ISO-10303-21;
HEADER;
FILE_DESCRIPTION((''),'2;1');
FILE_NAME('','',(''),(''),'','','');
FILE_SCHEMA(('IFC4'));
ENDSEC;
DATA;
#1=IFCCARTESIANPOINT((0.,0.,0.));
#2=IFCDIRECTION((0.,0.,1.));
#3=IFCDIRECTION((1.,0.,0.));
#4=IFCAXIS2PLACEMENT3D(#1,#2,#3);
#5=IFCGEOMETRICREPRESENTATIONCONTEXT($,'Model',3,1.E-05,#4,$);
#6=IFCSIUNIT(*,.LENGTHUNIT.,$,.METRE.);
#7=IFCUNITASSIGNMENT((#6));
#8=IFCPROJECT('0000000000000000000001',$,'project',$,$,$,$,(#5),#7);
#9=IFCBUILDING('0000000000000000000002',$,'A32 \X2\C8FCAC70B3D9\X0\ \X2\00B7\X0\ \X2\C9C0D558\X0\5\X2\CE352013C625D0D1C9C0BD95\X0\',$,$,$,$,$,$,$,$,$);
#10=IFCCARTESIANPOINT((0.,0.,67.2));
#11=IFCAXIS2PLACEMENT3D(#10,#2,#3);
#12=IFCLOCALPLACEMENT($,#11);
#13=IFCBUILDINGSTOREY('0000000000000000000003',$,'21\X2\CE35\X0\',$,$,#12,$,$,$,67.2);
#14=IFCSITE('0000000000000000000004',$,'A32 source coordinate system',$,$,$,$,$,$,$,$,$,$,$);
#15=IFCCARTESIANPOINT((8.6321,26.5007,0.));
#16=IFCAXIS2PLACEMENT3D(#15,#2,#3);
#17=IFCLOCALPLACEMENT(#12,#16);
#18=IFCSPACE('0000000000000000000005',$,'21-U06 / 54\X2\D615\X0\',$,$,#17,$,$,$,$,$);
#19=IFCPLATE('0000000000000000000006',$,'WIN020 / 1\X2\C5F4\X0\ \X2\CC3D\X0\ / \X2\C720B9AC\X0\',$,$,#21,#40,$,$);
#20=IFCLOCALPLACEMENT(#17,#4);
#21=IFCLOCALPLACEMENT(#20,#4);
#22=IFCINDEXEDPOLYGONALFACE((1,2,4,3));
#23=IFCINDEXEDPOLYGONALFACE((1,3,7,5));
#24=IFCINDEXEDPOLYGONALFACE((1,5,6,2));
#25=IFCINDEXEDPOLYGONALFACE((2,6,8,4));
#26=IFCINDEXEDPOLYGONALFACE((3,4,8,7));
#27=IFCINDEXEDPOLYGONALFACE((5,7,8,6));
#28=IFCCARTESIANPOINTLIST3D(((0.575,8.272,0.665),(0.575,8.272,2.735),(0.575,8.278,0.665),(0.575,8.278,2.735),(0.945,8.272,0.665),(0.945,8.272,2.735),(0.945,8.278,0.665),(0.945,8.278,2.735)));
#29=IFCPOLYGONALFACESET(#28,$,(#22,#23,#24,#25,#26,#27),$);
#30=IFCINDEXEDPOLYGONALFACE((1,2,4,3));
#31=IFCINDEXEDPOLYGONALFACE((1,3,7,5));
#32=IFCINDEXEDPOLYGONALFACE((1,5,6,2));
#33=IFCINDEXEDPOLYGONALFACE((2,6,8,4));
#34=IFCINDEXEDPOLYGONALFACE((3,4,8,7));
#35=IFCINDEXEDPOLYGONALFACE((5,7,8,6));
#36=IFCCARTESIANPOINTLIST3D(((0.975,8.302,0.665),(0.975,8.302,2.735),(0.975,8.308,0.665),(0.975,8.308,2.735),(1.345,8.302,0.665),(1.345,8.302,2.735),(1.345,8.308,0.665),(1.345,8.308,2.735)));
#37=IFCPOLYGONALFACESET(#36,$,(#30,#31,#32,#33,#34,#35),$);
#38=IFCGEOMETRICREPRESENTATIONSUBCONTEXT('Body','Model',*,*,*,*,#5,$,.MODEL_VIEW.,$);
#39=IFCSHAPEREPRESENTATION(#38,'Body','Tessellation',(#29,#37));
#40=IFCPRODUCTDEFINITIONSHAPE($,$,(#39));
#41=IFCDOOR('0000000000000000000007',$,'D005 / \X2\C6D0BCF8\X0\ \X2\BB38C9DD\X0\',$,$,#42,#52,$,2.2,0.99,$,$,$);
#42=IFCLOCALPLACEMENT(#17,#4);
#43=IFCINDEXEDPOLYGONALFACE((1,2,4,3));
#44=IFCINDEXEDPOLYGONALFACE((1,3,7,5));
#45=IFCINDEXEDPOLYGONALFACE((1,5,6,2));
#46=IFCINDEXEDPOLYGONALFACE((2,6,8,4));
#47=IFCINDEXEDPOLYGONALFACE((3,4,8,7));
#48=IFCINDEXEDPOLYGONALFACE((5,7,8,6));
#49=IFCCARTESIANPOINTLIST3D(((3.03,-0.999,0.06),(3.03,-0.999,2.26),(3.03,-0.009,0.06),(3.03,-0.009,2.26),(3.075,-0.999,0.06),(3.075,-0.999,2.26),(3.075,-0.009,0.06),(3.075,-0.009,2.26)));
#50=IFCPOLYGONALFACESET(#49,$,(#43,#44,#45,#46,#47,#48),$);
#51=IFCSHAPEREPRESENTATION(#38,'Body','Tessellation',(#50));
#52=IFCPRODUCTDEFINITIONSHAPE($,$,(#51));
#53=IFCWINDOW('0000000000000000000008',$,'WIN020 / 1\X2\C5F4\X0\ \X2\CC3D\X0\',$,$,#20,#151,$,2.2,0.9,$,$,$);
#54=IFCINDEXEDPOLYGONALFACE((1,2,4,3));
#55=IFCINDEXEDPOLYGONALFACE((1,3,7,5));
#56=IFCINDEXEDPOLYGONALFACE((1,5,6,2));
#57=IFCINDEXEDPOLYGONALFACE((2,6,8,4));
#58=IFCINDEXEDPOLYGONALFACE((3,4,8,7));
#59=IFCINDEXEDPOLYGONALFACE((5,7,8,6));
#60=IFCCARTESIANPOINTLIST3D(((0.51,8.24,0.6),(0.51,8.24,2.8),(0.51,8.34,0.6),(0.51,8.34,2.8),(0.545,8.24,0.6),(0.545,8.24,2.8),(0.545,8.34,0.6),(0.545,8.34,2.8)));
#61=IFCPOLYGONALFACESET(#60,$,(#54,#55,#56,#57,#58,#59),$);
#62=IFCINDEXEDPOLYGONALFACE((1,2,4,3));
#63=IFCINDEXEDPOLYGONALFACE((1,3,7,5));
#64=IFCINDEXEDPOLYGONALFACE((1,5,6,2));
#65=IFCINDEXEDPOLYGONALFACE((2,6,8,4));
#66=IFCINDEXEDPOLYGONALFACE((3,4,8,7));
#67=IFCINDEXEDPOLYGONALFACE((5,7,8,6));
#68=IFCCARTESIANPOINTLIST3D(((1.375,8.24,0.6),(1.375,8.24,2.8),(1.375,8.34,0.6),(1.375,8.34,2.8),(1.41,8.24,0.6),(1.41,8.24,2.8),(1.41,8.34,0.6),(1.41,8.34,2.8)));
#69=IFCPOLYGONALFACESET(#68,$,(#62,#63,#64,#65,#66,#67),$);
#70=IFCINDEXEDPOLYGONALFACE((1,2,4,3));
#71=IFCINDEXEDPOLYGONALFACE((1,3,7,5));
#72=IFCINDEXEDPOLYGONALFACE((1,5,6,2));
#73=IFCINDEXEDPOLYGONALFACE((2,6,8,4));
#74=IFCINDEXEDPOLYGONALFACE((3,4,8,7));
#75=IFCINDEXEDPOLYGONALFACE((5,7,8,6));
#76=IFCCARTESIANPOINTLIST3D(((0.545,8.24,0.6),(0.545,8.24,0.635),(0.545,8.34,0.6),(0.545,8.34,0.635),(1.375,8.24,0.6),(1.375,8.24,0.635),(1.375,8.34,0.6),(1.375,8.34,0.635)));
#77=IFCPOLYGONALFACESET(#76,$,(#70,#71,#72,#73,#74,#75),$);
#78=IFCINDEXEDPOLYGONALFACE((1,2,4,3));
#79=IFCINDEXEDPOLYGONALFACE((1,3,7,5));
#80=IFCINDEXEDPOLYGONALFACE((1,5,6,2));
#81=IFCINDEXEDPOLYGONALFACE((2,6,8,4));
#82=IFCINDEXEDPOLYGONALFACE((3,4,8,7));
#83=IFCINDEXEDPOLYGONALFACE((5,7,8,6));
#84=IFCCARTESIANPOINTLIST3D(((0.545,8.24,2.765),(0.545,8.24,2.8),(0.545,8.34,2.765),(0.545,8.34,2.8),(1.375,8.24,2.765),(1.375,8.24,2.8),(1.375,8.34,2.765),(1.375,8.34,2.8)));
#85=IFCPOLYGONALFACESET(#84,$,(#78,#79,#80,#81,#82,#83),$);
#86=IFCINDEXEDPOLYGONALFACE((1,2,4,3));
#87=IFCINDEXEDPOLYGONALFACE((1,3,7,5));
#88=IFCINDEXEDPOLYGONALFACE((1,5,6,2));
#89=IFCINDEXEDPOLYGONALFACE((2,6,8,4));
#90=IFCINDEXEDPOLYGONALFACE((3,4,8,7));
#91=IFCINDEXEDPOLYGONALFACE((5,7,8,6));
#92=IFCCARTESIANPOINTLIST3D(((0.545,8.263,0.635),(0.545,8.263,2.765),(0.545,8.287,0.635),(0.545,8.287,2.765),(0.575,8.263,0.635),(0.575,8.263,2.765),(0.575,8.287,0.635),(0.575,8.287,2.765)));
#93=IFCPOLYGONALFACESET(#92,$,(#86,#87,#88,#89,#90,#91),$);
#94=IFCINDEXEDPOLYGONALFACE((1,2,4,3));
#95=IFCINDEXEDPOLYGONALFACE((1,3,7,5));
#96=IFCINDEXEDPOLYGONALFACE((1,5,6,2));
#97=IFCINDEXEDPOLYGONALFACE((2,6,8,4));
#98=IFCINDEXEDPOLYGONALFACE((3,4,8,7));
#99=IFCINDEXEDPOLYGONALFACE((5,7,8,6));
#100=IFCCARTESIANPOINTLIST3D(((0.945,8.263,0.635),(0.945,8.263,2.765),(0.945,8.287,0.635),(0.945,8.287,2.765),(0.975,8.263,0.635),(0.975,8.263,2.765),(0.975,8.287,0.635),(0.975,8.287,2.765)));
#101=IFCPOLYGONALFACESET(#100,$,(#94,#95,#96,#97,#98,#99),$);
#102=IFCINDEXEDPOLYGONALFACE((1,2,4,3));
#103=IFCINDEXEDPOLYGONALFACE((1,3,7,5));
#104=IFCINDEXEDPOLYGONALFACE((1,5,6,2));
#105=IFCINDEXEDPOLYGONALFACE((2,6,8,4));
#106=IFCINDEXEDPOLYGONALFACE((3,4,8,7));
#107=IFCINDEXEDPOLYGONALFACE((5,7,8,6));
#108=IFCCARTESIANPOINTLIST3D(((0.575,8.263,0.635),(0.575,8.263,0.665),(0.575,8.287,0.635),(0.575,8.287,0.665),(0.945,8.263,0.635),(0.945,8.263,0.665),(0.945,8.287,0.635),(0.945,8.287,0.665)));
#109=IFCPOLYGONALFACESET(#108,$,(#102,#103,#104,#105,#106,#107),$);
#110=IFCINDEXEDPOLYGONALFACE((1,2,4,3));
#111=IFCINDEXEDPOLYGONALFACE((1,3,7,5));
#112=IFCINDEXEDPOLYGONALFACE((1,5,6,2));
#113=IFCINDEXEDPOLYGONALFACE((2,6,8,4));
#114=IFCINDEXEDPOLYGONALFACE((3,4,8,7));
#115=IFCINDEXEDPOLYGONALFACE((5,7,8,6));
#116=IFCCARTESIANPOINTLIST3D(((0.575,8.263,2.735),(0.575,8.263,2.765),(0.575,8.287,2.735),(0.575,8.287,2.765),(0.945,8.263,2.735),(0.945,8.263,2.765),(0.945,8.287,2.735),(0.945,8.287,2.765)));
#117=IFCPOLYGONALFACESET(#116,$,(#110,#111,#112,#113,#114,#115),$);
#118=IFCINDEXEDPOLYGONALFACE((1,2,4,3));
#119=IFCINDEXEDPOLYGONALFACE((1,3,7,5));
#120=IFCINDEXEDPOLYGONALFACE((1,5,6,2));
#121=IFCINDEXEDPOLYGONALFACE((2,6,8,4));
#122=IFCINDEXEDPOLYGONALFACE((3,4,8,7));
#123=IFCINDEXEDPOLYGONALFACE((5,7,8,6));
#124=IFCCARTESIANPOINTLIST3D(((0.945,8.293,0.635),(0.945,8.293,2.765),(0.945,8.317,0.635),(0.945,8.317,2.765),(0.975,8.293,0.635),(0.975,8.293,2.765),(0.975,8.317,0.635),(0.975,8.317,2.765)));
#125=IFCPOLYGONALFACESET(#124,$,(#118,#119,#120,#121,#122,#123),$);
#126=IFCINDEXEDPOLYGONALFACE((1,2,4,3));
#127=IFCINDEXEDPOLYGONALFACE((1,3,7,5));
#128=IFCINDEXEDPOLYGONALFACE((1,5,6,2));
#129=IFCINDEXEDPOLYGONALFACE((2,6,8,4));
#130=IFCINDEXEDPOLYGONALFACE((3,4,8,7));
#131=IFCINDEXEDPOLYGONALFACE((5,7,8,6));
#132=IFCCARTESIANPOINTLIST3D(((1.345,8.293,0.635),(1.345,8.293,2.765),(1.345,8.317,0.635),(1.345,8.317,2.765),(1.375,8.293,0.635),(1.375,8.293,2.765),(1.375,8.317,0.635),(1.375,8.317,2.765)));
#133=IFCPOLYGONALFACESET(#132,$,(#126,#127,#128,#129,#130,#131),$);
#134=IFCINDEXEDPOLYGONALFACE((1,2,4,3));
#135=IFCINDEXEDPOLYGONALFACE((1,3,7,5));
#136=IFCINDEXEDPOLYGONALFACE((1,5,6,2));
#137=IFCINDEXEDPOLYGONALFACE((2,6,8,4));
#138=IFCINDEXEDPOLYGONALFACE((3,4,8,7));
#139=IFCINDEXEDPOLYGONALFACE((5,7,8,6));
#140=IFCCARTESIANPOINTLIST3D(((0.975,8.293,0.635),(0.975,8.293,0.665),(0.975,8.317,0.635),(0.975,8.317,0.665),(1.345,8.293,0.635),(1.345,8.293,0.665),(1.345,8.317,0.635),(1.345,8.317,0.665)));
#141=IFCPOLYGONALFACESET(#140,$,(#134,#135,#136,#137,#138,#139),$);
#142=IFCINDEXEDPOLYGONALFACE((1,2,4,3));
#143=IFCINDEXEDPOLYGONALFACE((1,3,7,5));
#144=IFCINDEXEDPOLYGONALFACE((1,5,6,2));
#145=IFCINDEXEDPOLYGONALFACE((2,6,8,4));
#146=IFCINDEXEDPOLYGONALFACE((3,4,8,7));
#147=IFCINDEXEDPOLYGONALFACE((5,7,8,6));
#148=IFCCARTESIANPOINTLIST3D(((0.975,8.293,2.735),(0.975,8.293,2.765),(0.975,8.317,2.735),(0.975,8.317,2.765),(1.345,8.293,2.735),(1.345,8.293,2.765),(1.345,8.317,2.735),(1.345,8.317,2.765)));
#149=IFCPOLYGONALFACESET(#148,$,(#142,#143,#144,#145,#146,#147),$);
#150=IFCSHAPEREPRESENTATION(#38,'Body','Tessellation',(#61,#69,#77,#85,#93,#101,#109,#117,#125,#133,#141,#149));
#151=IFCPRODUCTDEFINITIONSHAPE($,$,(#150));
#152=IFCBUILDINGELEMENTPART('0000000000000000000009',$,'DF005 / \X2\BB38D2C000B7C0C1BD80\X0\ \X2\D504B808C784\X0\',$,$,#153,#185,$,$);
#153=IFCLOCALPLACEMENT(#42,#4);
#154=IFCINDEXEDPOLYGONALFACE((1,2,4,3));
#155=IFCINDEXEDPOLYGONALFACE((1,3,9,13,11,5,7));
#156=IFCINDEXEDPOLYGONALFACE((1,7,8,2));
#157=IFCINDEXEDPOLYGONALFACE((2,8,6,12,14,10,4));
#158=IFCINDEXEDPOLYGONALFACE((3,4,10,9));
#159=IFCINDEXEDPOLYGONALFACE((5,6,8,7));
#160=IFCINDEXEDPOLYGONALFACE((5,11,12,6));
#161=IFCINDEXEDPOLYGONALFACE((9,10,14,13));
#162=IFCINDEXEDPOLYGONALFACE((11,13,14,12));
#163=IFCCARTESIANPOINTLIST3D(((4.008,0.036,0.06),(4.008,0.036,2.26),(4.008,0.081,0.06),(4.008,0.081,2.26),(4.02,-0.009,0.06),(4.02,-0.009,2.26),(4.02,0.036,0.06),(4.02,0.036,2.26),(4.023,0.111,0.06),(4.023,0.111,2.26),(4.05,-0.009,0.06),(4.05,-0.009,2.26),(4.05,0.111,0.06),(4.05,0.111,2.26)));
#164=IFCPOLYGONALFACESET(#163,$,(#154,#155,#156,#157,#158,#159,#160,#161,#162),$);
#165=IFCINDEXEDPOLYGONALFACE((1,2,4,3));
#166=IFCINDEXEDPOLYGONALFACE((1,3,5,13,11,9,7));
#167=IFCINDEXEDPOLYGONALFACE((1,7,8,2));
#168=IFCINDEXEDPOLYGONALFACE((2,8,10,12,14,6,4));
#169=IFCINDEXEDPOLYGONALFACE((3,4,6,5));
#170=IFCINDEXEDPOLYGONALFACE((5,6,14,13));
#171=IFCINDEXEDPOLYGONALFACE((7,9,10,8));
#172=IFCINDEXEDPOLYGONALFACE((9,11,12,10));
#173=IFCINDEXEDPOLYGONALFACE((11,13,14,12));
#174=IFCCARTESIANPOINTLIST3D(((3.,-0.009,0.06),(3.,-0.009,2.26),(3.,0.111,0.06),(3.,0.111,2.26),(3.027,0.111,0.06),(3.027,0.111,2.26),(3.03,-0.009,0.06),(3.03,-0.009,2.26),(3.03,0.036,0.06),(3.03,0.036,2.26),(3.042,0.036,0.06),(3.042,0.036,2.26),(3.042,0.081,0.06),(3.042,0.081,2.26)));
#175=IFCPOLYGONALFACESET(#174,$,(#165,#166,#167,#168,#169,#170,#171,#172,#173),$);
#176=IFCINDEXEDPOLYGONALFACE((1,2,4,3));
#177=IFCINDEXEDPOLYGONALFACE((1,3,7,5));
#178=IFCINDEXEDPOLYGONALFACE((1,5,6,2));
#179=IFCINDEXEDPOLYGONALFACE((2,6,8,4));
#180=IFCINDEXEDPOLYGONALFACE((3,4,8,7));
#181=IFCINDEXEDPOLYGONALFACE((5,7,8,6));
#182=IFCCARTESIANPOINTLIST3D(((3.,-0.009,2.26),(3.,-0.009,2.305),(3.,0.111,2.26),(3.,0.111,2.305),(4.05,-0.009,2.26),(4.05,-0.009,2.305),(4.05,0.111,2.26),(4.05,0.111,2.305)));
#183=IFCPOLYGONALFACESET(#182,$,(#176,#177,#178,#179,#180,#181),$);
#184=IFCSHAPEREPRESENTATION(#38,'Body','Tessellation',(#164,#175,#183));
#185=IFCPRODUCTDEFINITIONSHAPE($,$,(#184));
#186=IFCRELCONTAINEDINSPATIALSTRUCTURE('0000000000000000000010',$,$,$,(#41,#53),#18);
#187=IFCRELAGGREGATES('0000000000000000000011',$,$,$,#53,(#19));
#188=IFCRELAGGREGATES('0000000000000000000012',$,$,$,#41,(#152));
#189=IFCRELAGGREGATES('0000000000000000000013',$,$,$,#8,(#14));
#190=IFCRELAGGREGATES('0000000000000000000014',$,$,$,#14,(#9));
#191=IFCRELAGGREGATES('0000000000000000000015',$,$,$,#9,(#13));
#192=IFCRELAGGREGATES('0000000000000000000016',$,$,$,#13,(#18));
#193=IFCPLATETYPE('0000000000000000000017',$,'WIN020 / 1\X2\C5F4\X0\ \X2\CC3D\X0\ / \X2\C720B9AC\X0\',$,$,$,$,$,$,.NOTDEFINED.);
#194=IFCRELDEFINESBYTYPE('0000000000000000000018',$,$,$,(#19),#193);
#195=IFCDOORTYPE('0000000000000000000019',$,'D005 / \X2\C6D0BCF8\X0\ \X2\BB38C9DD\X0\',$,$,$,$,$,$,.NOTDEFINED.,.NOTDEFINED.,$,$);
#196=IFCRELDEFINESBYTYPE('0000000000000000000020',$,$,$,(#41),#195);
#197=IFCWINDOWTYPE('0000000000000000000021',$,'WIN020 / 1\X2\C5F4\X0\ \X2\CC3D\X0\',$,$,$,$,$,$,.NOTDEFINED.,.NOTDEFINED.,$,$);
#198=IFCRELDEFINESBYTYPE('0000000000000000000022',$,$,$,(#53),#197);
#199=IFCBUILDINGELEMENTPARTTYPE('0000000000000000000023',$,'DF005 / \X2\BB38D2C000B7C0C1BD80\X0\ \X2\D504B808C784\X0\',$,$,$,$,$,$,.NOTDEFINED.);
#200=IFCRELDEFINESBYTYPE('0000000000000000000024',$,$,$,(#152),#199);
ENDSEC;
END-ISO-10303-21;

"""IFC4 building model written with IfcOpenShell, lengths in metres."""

from ifc_helpers import new_model, si_unit, frame, origin, origin_with_axes, place, context, subcontext, project, spatial, polyline, outline, extrude, source, transform, mapped, type_object, type_shapes, element, aggregate, save


model = new_model("IFC4")

# Units and contexts
model_context = context("Model", 3, precision=1e-05, world=origin_with_axes())
body_context = subcontext(model_context, "Body", "Model", "MODEL_VIEW")
ifc_project = project(units=[si_unit("LENGTHUNIT", "METRE")], contexts=[model_context])

# Plate
storey_placement = place(None, frame((0.0, 0.0, 67.2), z_axis=(0.0, 0.0, 1.0), x_axis=(1.0, 0.0, 0.0)))
space_1_placement = place(storey_placement, frame((8.6321, 26.5007, 0.0), z_axis=(0.0, 0.0, 1.0), x_axis=(1.0, 0.0, 0.0)))
plate_type_1 = type_object("IfcPlateType", Name="WIN020 / 1열 창 / 유리", PredefinedType="NOTDEFINED")
shared_shape_1 = source(origin(), body_context, "Body", "SweptSolid", [
    extrude(outline(polyline([(0.575, 8.272), (0.575, 8.278), (0.945, 8.278), (0.945, 8.272), (0.575, 8.272)])), frame((0.0, 0.0, 0.665)), (0.0, 0.0, 1.0), 2.07),
    extrude(outline(polyline([(0.975, 8.302), (0.975, 8.308), (1.345, 8.308), (1.345, 8.302), (0.975, 8.302)])), frame((0.0, 0.0, 0.665)), (0.0, 0.0, 1.0), 2.07),
])
type_shapes(plate_type_1, [shared_shape_1])
window_1_placement = place(space_1_placement, origin_with_axes())
plate_1_placement = place(window_1_placement, origin_with_axes())
plate_1 = element("IfcPlate", 1, at=plate_1_placement, type_object=plate_type_1, Name="WIN020 / 1열 창 / 유리", context=body_context, shape_type="MappedRepresentation", body=[
    mapped(shared_shape_1, transform((0.0, 0.0, 0.0), scale=1.0)),
])

# Site, building, storey, space
site = spatial("IfcSite", under=ifc_project, Name="A32 source coordinate system")
building = spatial("IfcBuilding", under=site, Name="A32 주거동 · 지하5층–옥탑지붕")
storey = spatial("IfcBuildingStorey", under=building, at=storey_placement, Name="21층", Elevation=67.2)
space_1 = spatial("IfcSpace", under=storey, at=space_1_placement, Name="21-U06 / 54형")

# Door
door_type_1 = type_object("IfcDoorType", Name="D005 / 원본 문짝", OperationType="NOTDEFINED", PredefinedType="NOTDEFINED")
shared_shape_2 = source(origin(), body_context, "Body", "SweptSolid", [
    extrude(outline(polyline([(3.075, -0.999), (3.03, -0.999), (3.03, -0.009), (3.075, -0.009), (3.075, -0.999)])), frame((0.0, 0.0, 0.06)), (0.0, 0.0, 1.0), 2.2),
])
type_shapes(door_type_1, [shared_shape_2])
door_1_placement = place(space_1_placement, origin_with_axes())
door_1 = element("IfcDoor", 2, at=door_1_placement, inside=space_1, type_object=door_type_1, Name="D005 / 원본 문짝", OverallHeight=2.2, OverallWidth=0.99, context=body_context, shape_type="MappedRepresentation", body=[
    mapped(shared_shape_2, transform((0.0, 0.0, 0.0), scale=1.0)),
])

# Window
window_type_1 = type_object("IfcWindowType", Name="WIN020 / 1열 창", PartitioningType="NOTDEFINED", PredefinedType="NOTDEFINED")
shared_shape_3 = source(origin(), body_context, "Body", "SweptSolid", [
    extrude(outline(polyline([(0.51, 8.24), (0.51, 8.34), (0.545, 8.34), (0.545, 8.24), (0.51, 8.24)])), frame((0.0, 0.0, 0.6)), (0.0, 0.0, 1.0), 2.2),
    extrude(outline(polyline([(1.375, 8.24), (1.375, 8.34), (1.41, 8.34), (1.41, 8.24), (1.375, 8.24)])), frame((0.0, 0.0, 0.6)), (0.0, 0.0, 1.0), 2.2),
    extrude(outline(polyline([(0.545, 8.24), (0.545, 8.34), (1.375, 8.34), (1.375, 8.24), (0.545, 8.24)])), frame((0.0, 0.0, 0.6)), (0.0, 0.0, 1.0), 0.035),
    extrude(outline(polyline([(0.545, 8.24), (0.545, 8.34), (1.375, 8.34), (1.375, 8.24), (0.545, 8.24)])), frame((0.0, 0.0, 2.765)), (0.0, 0.0, 1.0), 0.035),
    extrude(outline(polyline([(0.545, 8.263), (0.545, 8.287), (0.575, 8.287), (0.575, 8.263), (0.545, 8.263)])), frame((0.0, 0.0, 0.635)), (0.0, 0.0, 1.0), 2.13),
    extrude(outline(polyline([(0.945, 8.263), (0.945, 8.287), (0.975, 8.287), (0.975, 8.263), (0.945, 8.263)])), frame((0.0, 0.0, 0.635)), (0.0, 0.0, 1.0), 2.13),
    extrude(outline(polyline([(0.575, 8.263), (0.575, 8.287), (0.945, 8.287), (0.945, 8.263), (0.575, 8.263)])), frame((0.0, 0.0, 0.635)), (0.0, 0.0, 1.0), 0.03),
    extrude(outline(polyline([(0.575, 8.263), (0.575, 8.287), (0.945, 8.287), (0.945, 8.263), (0.575, 8.263)])), frame((0.0, 0.0, 2.735)), (0.0, 0.0, 1.0), 0.03),
    extrude(outline(polyline([(0.945, 8.293), (0.945, 8.317), (0.975, 8.317), (0.975, 8.293), (0.945, 8.293)])), frame((0.0, 0.0, 0.635)), (0.0, 0.0, 1.0), 2.13),
    extrude(outline(polyline([(1.345, 8.293), (1.345, 8.317), (1.375, 8.317), (1.375, 8.293), (1.345, 8.293)])), frame((0.0, 0.0, 0.635)), (0.0, 0.0, 1.0), 2.13),
    extrude(outline(polyline([(0.975, 8.293), (0.975, 8.317), (1.345, 8.317), (1.345, 8.293), (0.975, 8.293)])), frame((0.0, 0.0, 0.635)), (0.0, 0.0, 1.0), 0.03),
    extrude(outline(polyline([(0.975, 8.293), (0.975, 8.317), (1.345, 8.317), (1.345, 8.293), (0.975, 8.293)])), frame((0.0, 0.0, 2.735)), (0.0, 0.0, 1.0), 0.03),
])
type_shapes(window_type_1, [shared_shape_3])
window_1 = element("IfcWindow", 3, at=window_1_placement, inside=space_1, type_object=window_type_1, Name="WIN020 / 1열 창", OverallHeight=2.2, OverallWidth=0.9, context=body_context, shape_type="MappedRepresentation", body=[
    mapped(shared_shape_3, transform((0.0, 0.0, 0.0), scale=1.0)),
])
aggregate(window_1, [plate_1])

# Building element part
building_element_part_type_1 = type_object("IfcBuildingElementPartType", Name="DF005 / 문틀·상부 프레임", PredefinedType="NOTDEFINED")
shared_shape_4 = source(origin(), body_context, "Body", "SweptSolid", [
    extrude(outline(polyline([(4.02, -0.009), (4.02, 0.036), (4.008, 0.036), (4.008, 0.081), (4.023, 0.111), (4.05, 0.111), (4.05, -0.009), (4.02, -0.009)])), frame((0.0, 0.0, 0.06)), (0.0, 0.0, 1.0), 2.2),
    extrude(outline(polyline([(3.0, 0.111), (3.027, 0.111), (3.042, 0.081), (3.042, 0.036), (3.03, 0.036), (3.03, -0.009), (3.0, -0.009), (3.0, 0.111)])), frame((0.0, 0.0, 0.06)), (0.0, 0.0, 1.0), 2.2),
    extrude(outline(polyline([(3.0, -0.009), (3.0, 0.111), (4.05, 0.111), (4.05, -0.009), (3.0, -0.009)])), frame((0.0, 0.0, 2.26)), (0.0, 0.0, 1.0), 0.045),
])
type_shapes(building_element_part_type_1, [shared_shape_4])
building_element_part_1_placement = place(door_1_placement, origin_with_axes())
building_element_part_1 = element("IfcBuildingElementPart", 4, at=building_element_part_1_placement, type_object=building_element_part_type_1, Name="DF005 / 문틀·상부 프레임", context=body_context, shape_type="MappedRepresentation", body=[
    mapped(shared_shape_4, transform((0.0, 0.0, 0.0), scale=1.0)),
])
aggregate(door_1, [building_element_part_1])

save(model, "model.ifc")
